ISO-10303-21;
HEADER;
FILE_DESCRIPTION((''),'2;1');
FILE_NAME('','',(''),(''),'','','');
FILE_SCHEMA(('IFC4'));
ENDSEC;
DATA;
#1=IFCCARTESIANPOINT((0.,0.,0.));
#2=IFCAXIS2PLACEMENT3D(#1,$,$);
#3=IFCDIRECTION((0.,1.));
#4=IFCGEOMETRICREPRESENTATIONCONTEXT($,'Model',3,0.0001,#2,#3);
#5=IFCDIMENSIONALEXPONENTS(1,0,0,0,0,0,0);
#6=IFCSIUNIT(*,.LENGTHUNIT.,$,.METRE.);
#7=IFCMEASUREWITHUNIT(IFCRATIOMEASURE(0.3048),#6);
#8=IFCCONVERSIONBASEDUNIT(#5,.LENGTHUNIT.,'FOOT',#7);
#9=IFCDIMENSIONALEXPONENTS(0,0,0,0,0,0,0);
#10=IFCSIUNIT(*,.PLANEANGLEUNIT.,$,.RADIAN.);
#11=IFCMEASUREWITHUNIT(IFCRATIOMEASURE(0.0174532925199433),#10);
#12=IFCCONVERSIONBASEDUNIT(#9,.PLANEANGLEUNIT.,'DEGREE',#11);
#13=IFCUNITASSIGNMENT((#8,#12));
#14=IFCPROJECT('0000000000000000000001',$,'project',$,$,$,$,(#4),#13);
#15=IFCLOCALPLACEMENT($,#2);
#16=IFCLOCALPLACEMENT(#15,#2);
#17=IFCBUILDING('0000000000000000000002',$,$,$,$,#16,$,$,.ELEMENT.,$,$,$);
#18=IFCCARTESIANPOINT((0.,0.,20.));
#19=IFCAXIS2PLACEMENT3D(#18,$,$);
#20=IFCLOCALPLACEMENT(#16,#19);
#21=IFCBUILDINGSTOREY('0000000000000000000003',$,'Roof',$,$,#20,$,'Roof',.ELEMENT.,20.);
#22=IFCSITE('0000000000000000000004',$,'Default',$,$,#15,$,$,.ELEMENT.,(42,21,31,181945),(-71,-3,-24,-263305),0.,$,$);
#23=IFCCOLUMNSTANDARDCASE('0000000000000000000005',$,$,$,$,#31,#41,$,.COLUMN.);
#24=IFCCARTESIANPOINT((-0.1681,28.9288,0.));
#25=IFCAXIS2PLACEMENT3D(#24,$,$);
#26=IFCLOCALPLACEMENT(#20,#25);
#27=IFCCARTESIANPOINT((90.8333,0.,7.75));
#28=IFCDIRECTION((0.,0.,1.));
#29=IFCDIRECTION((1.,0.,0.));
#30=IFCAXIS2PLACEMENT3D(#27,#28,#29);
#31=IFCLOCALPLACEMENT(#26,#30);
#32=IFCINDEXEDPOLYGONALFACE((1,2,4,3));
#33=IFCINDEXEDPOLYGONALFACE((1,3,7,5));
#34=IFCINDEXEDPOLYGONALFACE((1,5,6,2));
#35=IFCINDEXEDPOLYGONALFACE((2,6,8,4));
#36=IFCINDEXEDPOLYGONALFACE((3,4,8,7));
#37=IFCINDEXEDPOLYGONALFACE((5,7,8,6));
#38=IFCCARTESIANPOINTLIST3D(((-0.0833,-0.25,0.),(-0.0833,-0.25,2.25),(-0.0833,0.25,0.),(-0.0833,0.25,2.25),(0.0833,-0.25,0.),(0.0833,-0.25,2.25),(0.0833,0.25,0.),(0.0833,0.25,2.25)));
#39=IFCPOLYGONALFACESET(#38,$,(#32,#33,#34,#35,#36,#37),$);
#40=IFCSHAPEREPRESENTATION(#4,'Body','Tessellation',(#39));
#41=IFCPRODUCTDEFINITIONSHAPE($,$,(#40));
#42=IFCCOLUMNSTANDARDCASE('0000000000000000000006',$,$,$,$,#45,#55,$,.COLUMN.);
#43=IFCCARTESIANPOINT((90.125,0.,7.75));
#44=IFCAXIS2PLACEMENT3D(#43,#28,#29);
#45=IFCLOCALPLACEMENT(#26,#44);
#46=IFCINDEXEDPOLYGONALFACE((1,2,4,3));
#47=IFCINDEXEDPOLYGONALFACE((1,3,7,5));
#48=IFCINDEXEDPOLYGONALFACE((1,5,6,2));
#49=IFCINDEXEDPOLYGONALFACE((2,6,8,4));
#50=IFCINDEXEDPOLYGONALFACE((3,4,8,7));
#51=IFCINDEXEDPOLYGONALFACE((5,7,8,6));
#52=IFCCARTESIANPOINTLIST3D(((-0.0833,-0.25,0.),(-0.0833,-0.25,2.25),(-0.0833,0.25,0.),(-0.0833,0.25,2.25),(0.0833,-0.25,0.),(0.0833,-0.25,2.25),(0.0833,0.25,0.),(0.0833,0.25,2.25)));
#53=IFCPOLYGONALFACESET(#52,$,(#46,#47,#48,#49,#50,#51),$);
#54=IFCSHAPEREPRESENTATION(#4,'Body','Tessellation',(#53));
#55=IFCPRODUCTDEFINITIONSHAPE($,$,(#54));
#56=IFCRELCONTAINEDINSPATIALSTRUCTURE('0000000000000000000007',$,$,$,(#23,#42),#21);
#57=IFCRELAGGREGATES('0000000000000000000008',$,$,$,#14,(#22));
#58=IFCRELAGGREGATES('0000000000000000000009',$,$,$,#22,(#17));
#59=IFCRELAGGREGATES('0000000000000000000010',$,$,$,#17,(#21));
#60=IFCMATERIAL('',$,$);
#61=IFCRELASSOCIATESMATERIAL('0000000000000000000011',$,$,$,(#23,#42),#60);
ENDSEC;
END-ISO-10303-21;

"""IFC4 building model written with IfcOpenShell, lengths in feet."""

from ifc_helpers import new_model, entity, si_unit, converted_unit, direction, frame, origin, place, context, project, spatial, rectangle, extrude, material, element, save


model = new_model("IFC4")

# Units and contexts
model_context = context("Model", 3, precision=0.0001, world=origin(), true_north=direction((0.0, 1.0)))
ifc_project = project(units=[converted_unit("LENGTHUNIT", "FOOT", entity("IfcRatioMeasure", 0.3048), si_unit("LENGTHUNIT", "METRE"), dimensions=[1, 0, 0, 0, 0, 0, 0]), converted_unit("PLANEANGLEUNIT", "DEGREE", entity("IfcRatioMeasure", 0.0174532925199433), si_unit("PLANEANGLEUNIT", "RADIAN"), dimensions=[0, 0, 0, 0, 0, 0, 0])], contexts=[model_context])

# Site, building, storey
site_placement = place(None, origin())
site = spatial("IfcSite", under=ifc_project, at=site_placement, Name="Default", CompositionType="ELEMENT", RefLatitude=(42, 21, 31, 181945), RefLongitude=(-71, -3, -24, -263305), RefElevation=0.0)
building_placement = place(site_placement, origin())
building = spatial("IfcBuilding", under=site, at=building_placement, CompositionType="ELEMENT")
storey_placement = place(building_placement, frame((0.0, 0.0, 20.0)))
storey = spatial("IfcBuildingStorey", under=building, at=storey_placement, Name="Roof", LongName="Roof", CompositionType="ELEMENT", Elevation=20.0)

# Columns
ifc_material = material(Name="")
placement = place(storey_placement, frame((-0.1681, 28.9288, 0.0)))
for number, where, z_axis, x_axis in (
    (1, (90.8333, 0.0, 7.75), (0.0, 0.0, 1.0), (1.0, 0.0, 0.0)),
    (2, (90.125, 0.0, 7.75), (0.0, 0.0, 1.0), (1.0, 0.0, 0.0)),
):
    element("IfcColumnStandardCase", number, at=place(placement, frame(where, z_axis=z_axis, x_axis=x_axis)), inside=storey, material=ifc_material, PredefinedType="COLUMN", context=model_context, shape_type="SweptSolid", body=[
        extrude(rectangle(XDim=0.1667, YDim=0.5), origin(), (0.0, 0.0, 1.0), 2.25),
    ])

save(model, "model.ifc")
